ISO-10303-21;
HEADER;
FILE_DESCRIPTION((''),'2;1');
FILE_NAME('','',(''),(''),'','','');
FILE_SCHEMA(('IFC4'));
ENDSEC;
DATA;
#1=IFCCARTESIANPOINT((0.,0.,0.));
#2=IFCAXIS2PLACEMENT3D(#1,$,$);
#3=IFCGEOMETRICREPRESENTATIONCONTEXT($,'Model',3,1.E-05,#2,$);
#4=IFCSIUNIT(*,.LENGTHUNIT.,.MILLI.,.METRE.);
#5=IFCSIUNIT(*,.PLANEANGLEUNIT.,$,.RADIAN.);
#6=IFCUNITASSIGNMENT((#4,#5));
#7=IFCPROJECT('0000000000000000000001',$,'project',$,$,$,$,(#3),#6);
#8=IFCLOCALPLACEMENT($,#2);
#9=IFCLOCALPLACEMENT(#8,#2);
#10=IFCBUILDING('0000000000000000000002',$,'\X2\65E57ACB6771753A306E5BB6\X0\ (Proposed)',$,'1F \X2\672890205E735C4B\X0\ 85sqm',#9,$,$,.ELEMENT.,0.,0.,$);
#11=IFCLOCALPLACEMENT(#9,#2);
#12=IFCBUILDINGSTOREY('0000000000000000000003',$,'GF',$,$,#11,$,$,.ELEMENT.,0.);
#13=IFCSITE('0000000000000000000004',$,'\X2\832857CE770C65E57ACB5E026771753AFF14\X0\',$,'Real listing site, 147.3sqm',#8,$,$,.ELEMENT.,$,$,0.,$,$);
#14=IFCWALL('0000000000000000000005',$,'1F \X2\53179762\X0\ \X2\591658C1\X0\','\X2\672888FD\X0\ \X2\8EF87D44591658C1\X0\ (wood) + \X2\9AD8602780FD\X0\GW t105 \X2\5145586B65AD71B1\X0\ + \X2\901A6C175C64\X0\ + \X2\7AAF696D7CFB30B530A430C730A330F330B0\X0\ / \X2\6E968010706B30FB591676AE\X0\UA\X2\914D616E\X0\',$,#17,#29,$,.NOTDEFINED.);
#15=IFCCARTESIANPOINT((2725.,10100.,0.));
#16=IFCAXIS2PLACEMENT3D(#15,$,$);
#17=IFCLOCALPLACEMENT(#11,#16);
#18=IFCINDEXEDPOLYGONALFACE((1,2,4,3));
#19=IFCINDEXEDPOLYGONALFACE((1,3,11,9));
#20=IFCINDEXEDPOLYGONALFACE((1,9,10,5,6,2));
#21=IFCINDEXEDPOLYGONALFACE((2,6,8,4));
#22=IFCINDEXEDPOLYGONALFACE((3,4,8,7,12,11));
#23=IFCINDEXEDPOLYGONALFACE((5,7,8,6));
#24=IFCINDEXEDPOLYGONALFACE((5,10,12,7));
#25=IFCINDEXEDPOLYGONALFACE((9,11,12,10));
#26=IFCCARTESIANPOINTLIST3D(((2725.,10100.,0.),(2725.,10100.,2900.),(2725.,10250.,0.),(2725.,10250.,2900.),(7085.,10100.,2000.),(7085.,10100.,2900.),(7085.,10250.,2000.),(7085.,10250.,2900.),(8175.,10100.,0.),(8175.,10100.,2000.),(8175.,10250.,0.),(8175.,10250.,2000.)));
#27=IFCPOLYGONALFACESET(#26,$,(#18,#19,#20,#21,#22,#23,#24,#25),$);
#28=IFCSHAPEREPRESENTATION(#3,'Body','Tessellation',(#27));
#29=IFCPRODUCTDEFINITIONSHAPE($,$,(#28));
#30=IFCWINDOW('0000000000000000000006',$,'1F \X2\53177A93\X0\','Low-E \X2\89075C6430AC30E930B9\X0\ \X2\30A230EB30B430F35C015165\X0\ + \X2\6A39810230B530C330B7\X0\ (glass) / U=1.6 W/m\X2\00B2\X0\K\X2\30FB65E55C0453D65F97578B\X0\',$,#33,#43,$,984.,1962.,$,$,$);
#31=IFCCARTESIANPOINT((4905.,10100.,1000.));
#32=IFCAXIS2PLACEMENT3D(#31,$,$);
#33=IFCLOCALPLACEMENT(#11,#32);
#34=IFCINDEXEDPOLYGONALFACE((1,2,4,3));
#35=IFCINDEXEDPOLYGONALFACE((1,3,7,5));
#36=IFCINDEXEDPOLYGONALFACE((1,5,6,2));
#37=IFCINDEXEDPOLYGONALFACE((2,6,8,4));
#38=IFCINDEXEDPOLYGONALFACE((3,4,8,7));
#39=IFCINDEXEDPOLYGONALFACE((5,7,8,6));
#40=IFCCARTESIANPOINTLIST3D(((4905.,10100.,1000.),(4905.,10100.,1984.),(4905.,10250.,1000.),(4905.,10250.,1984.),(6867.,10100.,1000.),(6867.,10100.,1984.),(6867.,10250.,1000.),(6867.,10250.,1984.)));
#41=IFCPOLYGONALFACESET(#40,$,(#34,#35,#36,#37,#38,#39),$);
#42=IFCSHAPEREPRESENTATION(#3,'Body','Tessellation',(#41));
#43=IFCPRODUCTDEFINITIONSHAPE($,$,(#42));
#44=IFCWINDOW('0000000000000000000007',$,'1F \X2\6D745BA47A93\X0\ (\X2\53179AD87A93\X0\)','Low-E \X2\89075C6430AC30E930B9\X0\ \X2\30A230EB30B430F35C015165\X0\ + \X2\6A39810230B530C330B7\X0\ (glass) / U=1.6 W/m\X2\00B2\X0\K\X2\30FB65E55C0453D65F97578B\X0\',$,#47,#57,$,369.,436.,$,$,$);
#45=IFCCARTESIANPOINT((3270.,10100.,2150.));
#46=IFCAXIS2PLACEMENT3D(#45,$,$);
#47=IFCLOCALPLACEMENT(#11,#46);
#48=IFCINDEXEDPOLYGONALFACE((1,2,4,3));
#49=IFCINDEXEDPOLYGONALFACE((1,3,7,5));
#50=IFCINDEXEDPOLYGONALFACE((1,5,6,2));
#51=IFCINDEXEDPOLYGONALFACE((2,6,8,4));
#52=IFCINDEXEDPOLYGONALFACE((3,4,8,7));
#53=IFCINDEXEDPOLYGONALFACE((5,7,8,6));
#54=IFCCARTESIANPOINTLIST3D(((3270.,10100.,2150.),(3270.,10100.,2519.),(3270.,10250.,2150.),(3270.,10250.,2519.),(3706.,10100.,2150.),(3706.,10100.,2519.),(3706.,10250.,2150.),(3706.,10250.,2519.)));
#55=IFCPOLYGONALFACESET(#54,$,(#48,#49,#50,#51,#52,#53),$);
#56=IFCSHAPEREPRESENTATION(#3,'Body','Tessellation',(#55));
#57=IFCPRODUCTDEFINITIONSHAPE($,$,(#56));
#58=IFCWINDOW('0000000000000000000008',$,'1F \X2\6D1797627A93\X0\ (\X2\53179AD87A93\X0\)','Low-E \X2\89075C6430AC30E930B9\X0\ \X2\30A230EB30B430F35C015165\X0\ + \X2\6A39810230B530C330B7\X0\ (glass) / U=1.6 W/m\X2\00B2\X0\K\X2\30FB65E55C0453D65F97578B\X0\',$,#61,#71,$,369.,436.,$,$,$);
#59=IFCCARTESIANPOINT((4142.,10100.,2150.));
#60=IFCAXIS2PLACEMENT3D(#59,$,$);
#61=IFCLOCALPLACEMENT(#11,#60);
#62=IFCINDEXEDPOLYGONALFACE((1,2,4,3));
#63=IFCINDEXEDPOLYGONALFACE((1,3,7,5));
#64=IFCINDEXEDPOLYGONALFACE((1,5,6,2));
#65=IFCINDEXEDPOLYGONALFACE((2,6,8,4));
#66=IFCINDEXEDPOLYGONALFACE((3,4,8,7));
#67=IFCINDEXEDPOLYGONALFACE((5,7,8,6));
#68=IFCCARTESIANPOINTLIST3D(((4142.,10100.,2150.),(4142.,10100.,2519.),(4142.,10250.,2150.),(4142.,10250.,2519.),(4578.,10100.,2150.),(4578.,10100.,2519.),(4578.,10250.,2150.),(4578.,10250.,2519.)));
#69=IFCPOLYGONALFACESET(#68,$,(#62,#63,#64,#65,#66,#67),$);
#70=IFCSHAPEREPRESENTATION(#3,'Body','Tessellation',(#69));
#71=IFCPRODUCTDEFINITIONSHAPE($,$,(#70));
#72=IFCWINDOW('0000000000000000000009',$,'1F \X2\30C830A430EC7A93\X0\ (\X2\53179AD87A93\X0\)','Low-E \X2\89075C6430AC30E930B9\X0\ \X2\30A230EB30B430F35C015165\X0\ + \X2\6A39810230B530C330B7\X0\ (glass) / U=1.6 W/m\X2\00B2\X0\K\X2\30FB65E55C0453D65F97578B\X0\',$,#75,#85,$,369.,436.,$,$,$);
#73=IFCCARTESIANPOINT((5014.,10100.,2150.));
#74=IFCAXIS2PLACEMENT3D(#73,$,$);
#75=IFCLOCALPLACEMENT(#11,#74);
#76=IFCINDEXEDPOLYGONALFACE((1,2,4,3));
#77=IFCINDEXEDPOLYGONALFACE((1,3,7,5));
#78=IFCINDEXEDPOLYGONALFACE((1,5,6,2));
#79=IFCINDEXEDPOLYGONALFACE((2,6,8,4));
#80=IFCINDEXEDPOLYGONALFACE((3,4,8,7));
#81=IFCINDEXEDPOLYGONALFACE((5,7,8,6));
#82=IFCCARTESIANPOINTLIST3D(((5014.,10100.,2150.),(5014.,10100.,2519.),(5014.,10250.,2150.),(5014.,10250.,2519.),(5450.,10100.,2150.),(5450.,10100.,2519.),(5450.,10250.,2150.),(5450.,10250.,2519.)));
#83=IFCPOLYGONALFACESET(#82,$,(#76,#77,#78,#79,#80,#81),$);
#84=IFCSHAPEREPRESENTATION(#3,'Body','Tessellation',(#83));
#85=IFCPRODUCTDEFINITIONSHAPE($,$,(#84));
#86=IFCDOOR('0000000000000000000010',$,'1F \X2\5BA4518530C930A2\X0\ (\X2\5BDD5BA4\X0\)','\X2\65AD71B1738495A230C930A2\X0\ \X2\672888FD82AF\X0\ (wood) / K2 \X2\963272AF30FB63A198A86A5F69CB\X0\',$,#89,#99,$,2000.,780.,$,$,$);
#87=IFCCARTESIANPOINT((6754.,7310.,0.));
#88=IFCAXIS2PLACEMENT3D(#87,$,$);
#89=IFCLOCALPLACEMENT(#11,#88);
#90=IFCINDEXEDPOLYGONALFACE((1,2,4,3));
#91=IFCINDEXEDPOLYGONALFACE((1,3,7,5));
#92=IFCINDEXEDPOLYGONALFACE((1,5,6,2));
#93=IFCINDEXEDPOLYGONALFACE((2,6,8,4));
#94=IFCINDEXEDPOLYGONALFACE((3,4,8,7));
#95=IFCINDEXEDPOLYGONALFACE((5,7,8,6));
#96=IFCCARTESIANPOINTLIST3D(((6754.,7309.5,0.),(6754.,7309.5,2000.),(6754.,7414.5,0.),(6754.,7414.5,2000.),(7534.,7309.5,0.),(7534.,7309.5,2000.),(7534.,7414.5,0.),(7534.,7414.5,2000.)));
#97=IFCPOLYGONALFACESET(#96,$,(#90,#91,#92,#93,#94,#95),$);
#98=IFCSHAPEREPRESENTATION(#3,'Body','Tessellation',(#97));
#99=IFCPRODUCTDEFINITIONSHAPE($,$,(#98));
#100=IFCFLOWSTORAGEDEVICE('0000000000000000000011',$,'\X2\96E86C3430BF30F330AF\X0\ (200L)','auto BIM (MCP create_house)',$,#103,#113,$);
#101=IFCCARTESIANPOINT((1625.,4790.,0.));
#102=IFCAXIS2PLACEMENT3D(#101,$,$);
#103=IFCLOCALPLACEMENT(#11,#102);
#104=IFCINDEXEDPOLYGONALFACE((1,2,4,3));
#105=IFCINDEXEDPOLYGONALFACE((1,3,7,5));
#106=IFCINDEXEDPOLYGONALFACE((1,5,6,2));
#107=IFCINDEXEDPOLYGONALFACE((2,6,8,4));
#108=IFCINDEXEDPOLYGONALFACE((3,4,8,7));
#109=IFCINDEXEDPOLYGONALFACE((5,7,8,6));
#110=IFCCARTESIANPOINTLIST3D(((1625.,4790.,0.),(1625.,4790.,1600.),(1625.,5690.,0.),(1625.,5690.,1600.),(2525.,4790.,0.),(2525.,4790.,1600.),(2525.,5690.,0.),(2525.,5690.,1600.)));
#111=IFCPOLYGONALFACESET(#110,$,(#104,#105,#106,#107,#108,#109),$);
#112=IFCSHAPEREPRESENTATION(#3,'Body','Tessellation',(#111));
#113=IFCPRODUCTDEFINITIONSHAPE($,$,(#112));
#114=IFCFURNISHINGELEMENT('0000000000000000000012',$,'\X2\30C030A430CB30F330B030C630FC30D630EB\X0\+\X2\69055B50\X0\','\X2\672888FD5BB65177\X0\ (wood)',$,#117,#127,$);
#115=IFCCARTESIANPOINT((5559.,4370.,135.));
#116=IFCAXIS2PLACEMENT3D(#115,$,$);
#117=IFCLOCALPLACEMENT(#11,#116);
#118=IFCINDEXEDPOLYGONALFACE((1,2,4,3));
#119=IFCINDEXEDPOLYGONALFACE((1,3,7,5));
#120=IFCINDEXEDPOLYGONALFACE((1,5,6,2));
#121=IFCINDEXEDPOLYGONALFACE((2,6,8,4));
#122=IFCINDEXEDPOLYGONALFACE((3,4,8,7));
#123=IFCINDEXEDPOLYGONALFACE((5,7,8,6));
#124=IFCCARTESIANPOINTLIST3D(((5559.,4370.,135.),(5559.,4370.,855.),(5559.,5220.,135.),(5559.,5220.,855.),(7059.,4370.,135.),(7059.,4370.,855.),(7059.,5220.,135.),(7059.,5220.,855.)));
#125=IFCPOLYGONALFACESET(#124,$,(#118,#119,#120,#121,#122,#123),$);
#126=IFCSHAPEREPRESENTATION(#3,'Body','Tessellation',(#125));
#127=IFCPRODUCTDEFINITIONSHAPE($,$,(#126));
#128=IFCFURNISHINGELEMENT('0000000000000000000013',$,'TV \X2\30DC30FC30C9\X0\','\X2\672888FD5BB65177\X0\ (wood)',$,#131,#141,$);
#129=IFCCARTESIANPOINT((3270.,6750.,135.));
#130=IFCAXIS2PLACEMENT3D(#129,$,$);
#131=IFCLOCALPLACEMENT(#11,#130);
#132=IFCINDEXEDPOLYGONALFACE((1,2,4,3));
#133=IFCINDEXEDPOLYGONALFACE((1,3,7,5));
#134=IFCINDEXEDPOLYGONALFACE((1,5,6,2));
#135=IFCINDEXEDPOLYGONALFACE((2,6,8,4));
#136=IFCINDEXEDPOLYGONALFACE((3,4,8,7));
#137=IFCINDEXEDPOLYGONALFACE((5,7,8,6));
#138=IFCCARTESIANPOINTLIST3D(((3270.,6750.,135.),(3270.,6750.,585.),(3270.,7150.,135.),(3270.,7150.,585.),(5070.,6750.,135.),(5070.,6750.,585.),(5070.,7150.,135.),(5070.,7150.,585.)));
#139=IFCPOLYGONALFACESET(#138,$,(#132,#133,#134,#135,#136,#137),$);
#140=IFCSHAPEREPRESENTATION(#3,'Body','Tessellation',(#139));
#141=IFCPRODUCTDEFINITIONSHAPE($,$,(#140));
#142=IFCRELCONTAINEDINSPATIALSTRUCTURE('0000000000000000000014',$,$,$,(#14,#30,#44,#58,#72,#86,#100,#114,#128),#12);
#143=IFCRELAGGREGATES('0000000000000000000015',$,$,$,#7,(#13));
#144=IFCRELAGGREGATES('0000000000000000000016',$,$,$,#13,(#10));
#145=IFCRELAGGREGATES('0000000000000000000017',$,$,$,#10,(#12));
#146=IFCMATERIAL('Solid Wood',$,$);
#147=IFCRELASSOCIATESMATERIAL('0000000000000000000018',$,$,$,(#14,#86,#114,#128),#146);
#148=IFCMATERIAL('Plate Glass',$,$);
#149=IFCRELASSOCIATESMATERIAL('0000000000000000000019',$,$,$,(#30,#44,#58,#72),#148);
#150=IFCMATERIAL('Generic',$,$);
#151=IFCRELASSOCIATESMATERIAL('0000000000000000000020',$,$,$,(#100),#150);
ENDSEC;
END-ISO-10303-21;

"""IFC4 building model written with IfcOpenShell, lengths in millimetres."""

from ifc_helpers import new_model, si_unit, frame, frame_2d, origin, place, context, project, spatial, rectangle, extrude, material, element, fill, save


model = new_model("IFC4")

# Units and contexts
model_context = context("Model", 3, precision=1e-05, world=origin())
ifc_project = project(units=[si_unit("LENGTHUNIT", "METRE", prefix="MILLI"), si_unit("PLANEANGLEUNIT", "RADIAN")], contexts=[model_context])

# Site, building, storey
site_placement = place(None, origin())
site = spatial("IfcSite", under=ifc_project, at=site_placement, Name="茨城県日立市東町４", ObjectType="Real listing site, 147.3sqm", CompositionType="ELEMENT", RefElevation=0.0)
building_placement = place(site_placement, origin())
building = spatial("IfcBuilding", under=site, at=building_placement, Name="日立東町の家 (Proposed)", ObjectType="1F 木造平屋 85sqm", CompositionType="ELEMENT", ElevationOfRefHeight=0.0, ElevationOfTerrain=0.0)
storey_placement = place(building_placement, origin())
storey = spatial("IfcBuildingStorey", under=building, at=storey_placement, Name="GF", CompositionType="ELEMENT", Elevation=0.0)

# Wall, openings, windows
ifc_material_1 = material(Name="Solid Wood")
wall_1_placement = place(storey_placement, frame((2725.0, 10100.0, 0.0)))
wall_1 = element("IfcWall", 1, at=wall_1_placement, inside=storey, material=ifc_material_1, Name="1F 北面 外壁", Description="木製 軸組外壁 (wood) + 高性能GW t105 充填断熱 + 通気層 + 窯業系サイディング / 準耐火・外皮UA配慮", PredefinedType="NOTDEFINED", context=model_context, shape_type="SweptSolid", body=[
    extrude(rectangle(XDim=5450.0, YDim=150.0, at=frame_2d((2725.0, 75.0))), frame((2725.0, 10100.0, 0.0)), (0.0, 0.0, 1.0), 2900.0),
])
opening_1_placement = place(storey_placement, frame((4905.0, 10100.0, 1000.0)))
opening_1 = element("IfcOpeningElement", 2, at=opening_1_placement, cuts=wall_1, PredefinedType="NOTDEFINED", context=model_context, shape_type="SweptSolid", body=[
    extrude(rectangle(XDim=1962.0, YDim=150.0, at=frame_2d((981.0, 75.0))), frame((4905.0, 10100.0, 1000.0)), (0.0, 0.0, 1.0), 984.0),
])
opening_2_placement = place(storey_placement, frame((3270.0, 10100.0, 2150.0)))
opening_2 = element("IfcOpeningElement", 3, at=opening_2_placement, cuts=wall_1, PredefinedType="NOTDEFINED", context=model_context, shape_type="SweptSolid", body=[
    extrude(rectangle(XDim=436.0, YDim=150.0, at=frame_2d((218.0, 75.0))), frame((3270.0, 10100.0, 2150.0)), (0.0, 0.0, 1.0), 369.0),
])
opening_3_placement = place(storey_placement, frame((4142.0, 10100.0, 2150.0)))
opening_3 = element("IfcOpeningElement", 4, at=opening_3_placement, cuts=wall_1, PredefinedType="NOTDEFINED", context=model_context, shape_type="SweptSolid", body=[
    extrude(rectangle(XDim=436.0, YDim=150.0, at=frame_2d((218.0, 75.0))), frame((4142.0, 10100.0, 2150.0)), (0.0, 0.0, 1.0), 369.0),
])
opening_4_placement = place(storey_placement, frame((5014.0, 10100.0, 2150.0)))
opening_4 = element("IfcOpeningElement", 5, at=opening_4_placement, cuts=wall_1, PredefinedType="NOTDEFINED", context=model_context, shape_type="SweptSolid", body=[
    extrude(rectangle(XDim=436.0, YDim=150.0, at=frame_2d((218.0, 75.0))), frame((5014.0, 10100.0, 2150.0)), (0.0, 0.0, 1.0), 369.0),
])
ifc_material_2 = material(Name="Plate Glass")
window_1_placement = place(storey_placement, frame((4905.0, 10100.0, 1000.0)))
window_1 = element("IfcWindow", 6, at=window_1_placement, inside=storey, material=ifc_material_2, Name="1F 北窓", Description="Low-E 複層ガラス アルゴン封入 + 樹脂サッシ (glass) / U=1.6 W/m²K・日射取得型", OverallHeight=984.0, OverallWidth=1962.0, context=model_context, shape_type="SweptSolid", body=[
    extrude(rectangle(XDim=1962.0, YDim=150.0, at=frame_2d((981.0, 75.0))), frame((4905.0, 10100.0, 1000.0)), (0.0, 0.0, 1.0), 984.0),
])
fill(opening_1, window_1)
window_2_placement = place(storey_placement, frame((3270.0, 10100.0, 2150.0)))
window_2 = element("IfcWindow", 7, at=window_2_placement, inside=storey, material=ifc_material_2, Name="1F 浴室窓 (北高窓)", Description="Low-E 複層ガラス アルゴン封入 + 樹脂サッシ (glass) / U=1.6 W/m²K・日射取得型", OverallHeight=369.0, OverallWidth=436.0, context=model_context, shape_type="SweptSolid", body=[
    extrude(rectangle(XDim=436.0, YDim=150.0, at=frame_2d((218.0, 75.0))), frame((3270.0, 10100.0, 2150.0)), (0.0, 0.0, 1.0), 369.0),
])
fill(opening_2, window_2)
window_3_placement = place(storey_placement, frame((4142.0, 10100.0, 2150.0)))
window_3 = element("IfcWindow", 8, at=window_3_placement, inside=storey, material=ifc_material_2, Name="1F 洗面窓 (北高窓)", Description="Low-E 複層ガラス アルゴン封入 + 樹脂サッシ (glass) / U=1.6 W/m²K・日射取得型", OverallHeight=369.0, OverallWidth=436.0, context=model_context, shape_type="SweptSolid", body=[
    extrude(rectangle(XDim=436.0, YDim=150.0, at=frame_2d((218.0, 75.0))), frame((4142.0, 10100.0, 2150.0)), (0.0, 0.0, 1.0), 369.0),
])
fill(opening_3, window_3)
window_4_placement = place(storey_placement, frame((5014.0, 10100.0, 2150.0)))
window_4 = element("IfcWindow", 9, at=window_4_placement, inside=storey, material=ifc_material_2, Name="1F トイレ窓 (北高窓)", Description="Low-E 複層ガラス アルゴン封入 + 樹脂サッシ (glass) / U=1.6 W/m²K・日射取得型", OverallHeight=369.0, OverallWidth=436.0, context=model_context, shape_type="SweptSolid", body=[
    extrude(rectangle(XDim=436.0, YDim=150.0, at=frame_2d((218.0, 75.0))), frame((5014.0, 10100.0, 2150.0)), (0.0, 0.0, 1.0), 369.0),
])
fill(opening_4, window_4)

# Door
door_1_placement = place(storey_placement, frame((6754.0, 7310.0, 0.0)))
element("IfcDoor", 10, at=door_1_placement, inside=storey, material=ifc_material_1, Name="1F 室内ドア (寝室)", Description="断熱玄関ドア 木製芯 (wood) / K2 防犯・採風機構", OverallHeight=2000.0, OverallWidth=780.0, context=model_context, shape_type="SweptSolid", body=[
    extrude(rectangle(XDim=780.0, YDim=105.0, at=frame_2d((390.0, 52.0))), frame((6754.0, 7310.0, 0.0)), (0.0, 0.0, 1.0), 2000.0),
])

# Flow storage device
ifc_material_3 = material(Name="Generic")
flow_storage_device_placement = place(storey_placement, frame((1625.0, 4790.0, 0.0)))
element("IfcFlowStorageDevice", 11, at=flow_storage_device_placement, inside=storey, material=ifc_material_3, Name="雨水タンク (200L)", Description="auto BIM (MCP create_house)", context=model_context, shape_type="SweptSolid", body=[
    extrude(rectangle(XDim=900.0, YDim=900.0, at=frame_2d((450.0, 450.0))), frame((1625.0, 4790.0, 0.0)), (0.0, 0.0, 1.0), 1600.0),
])

# Furnishing elements
furnishing_1_placement = place(storey_placement, frame((5559.0, 4370.0, 135.0)))
element("IfcFurnishingElement", 12, at=furnishing_1_placement, inside=storey, material=ifc_material_1, Name="ダイニングテーブル+椅子", Description="木製家具 (wood)", context=model_context, shape_type="SweptSolid", body=[
    extrude(rectangle(XDim=1500.0, YDim=850.0, at=frame_2d((750.0, 425.0))), frame((5559.0, 4370.0, 135.0)), (0.0, 0.0, 1.0), 720.0),
])
furnishing_2_placement = place(storey_placement, frame((3270.0, 6750.0, 135.0)))
element("IfcFurnishingElement", 13, at=furnishing_2_placement, inside=storey, material=ifc_material_1, Name="TV ボード", Description="木製家具 (wood)", context=model_context, shape_type="SweptSolid", body=[
    extrude(rectangle(XDim=1800.0, YDim=400.0, at=frame_2d((900.0, 200.0))), frame((3270.0, 6750.0, 135.0)), (0.0, 0.0, 1.0), 450.0),
])

save(model, "model.ifc")
